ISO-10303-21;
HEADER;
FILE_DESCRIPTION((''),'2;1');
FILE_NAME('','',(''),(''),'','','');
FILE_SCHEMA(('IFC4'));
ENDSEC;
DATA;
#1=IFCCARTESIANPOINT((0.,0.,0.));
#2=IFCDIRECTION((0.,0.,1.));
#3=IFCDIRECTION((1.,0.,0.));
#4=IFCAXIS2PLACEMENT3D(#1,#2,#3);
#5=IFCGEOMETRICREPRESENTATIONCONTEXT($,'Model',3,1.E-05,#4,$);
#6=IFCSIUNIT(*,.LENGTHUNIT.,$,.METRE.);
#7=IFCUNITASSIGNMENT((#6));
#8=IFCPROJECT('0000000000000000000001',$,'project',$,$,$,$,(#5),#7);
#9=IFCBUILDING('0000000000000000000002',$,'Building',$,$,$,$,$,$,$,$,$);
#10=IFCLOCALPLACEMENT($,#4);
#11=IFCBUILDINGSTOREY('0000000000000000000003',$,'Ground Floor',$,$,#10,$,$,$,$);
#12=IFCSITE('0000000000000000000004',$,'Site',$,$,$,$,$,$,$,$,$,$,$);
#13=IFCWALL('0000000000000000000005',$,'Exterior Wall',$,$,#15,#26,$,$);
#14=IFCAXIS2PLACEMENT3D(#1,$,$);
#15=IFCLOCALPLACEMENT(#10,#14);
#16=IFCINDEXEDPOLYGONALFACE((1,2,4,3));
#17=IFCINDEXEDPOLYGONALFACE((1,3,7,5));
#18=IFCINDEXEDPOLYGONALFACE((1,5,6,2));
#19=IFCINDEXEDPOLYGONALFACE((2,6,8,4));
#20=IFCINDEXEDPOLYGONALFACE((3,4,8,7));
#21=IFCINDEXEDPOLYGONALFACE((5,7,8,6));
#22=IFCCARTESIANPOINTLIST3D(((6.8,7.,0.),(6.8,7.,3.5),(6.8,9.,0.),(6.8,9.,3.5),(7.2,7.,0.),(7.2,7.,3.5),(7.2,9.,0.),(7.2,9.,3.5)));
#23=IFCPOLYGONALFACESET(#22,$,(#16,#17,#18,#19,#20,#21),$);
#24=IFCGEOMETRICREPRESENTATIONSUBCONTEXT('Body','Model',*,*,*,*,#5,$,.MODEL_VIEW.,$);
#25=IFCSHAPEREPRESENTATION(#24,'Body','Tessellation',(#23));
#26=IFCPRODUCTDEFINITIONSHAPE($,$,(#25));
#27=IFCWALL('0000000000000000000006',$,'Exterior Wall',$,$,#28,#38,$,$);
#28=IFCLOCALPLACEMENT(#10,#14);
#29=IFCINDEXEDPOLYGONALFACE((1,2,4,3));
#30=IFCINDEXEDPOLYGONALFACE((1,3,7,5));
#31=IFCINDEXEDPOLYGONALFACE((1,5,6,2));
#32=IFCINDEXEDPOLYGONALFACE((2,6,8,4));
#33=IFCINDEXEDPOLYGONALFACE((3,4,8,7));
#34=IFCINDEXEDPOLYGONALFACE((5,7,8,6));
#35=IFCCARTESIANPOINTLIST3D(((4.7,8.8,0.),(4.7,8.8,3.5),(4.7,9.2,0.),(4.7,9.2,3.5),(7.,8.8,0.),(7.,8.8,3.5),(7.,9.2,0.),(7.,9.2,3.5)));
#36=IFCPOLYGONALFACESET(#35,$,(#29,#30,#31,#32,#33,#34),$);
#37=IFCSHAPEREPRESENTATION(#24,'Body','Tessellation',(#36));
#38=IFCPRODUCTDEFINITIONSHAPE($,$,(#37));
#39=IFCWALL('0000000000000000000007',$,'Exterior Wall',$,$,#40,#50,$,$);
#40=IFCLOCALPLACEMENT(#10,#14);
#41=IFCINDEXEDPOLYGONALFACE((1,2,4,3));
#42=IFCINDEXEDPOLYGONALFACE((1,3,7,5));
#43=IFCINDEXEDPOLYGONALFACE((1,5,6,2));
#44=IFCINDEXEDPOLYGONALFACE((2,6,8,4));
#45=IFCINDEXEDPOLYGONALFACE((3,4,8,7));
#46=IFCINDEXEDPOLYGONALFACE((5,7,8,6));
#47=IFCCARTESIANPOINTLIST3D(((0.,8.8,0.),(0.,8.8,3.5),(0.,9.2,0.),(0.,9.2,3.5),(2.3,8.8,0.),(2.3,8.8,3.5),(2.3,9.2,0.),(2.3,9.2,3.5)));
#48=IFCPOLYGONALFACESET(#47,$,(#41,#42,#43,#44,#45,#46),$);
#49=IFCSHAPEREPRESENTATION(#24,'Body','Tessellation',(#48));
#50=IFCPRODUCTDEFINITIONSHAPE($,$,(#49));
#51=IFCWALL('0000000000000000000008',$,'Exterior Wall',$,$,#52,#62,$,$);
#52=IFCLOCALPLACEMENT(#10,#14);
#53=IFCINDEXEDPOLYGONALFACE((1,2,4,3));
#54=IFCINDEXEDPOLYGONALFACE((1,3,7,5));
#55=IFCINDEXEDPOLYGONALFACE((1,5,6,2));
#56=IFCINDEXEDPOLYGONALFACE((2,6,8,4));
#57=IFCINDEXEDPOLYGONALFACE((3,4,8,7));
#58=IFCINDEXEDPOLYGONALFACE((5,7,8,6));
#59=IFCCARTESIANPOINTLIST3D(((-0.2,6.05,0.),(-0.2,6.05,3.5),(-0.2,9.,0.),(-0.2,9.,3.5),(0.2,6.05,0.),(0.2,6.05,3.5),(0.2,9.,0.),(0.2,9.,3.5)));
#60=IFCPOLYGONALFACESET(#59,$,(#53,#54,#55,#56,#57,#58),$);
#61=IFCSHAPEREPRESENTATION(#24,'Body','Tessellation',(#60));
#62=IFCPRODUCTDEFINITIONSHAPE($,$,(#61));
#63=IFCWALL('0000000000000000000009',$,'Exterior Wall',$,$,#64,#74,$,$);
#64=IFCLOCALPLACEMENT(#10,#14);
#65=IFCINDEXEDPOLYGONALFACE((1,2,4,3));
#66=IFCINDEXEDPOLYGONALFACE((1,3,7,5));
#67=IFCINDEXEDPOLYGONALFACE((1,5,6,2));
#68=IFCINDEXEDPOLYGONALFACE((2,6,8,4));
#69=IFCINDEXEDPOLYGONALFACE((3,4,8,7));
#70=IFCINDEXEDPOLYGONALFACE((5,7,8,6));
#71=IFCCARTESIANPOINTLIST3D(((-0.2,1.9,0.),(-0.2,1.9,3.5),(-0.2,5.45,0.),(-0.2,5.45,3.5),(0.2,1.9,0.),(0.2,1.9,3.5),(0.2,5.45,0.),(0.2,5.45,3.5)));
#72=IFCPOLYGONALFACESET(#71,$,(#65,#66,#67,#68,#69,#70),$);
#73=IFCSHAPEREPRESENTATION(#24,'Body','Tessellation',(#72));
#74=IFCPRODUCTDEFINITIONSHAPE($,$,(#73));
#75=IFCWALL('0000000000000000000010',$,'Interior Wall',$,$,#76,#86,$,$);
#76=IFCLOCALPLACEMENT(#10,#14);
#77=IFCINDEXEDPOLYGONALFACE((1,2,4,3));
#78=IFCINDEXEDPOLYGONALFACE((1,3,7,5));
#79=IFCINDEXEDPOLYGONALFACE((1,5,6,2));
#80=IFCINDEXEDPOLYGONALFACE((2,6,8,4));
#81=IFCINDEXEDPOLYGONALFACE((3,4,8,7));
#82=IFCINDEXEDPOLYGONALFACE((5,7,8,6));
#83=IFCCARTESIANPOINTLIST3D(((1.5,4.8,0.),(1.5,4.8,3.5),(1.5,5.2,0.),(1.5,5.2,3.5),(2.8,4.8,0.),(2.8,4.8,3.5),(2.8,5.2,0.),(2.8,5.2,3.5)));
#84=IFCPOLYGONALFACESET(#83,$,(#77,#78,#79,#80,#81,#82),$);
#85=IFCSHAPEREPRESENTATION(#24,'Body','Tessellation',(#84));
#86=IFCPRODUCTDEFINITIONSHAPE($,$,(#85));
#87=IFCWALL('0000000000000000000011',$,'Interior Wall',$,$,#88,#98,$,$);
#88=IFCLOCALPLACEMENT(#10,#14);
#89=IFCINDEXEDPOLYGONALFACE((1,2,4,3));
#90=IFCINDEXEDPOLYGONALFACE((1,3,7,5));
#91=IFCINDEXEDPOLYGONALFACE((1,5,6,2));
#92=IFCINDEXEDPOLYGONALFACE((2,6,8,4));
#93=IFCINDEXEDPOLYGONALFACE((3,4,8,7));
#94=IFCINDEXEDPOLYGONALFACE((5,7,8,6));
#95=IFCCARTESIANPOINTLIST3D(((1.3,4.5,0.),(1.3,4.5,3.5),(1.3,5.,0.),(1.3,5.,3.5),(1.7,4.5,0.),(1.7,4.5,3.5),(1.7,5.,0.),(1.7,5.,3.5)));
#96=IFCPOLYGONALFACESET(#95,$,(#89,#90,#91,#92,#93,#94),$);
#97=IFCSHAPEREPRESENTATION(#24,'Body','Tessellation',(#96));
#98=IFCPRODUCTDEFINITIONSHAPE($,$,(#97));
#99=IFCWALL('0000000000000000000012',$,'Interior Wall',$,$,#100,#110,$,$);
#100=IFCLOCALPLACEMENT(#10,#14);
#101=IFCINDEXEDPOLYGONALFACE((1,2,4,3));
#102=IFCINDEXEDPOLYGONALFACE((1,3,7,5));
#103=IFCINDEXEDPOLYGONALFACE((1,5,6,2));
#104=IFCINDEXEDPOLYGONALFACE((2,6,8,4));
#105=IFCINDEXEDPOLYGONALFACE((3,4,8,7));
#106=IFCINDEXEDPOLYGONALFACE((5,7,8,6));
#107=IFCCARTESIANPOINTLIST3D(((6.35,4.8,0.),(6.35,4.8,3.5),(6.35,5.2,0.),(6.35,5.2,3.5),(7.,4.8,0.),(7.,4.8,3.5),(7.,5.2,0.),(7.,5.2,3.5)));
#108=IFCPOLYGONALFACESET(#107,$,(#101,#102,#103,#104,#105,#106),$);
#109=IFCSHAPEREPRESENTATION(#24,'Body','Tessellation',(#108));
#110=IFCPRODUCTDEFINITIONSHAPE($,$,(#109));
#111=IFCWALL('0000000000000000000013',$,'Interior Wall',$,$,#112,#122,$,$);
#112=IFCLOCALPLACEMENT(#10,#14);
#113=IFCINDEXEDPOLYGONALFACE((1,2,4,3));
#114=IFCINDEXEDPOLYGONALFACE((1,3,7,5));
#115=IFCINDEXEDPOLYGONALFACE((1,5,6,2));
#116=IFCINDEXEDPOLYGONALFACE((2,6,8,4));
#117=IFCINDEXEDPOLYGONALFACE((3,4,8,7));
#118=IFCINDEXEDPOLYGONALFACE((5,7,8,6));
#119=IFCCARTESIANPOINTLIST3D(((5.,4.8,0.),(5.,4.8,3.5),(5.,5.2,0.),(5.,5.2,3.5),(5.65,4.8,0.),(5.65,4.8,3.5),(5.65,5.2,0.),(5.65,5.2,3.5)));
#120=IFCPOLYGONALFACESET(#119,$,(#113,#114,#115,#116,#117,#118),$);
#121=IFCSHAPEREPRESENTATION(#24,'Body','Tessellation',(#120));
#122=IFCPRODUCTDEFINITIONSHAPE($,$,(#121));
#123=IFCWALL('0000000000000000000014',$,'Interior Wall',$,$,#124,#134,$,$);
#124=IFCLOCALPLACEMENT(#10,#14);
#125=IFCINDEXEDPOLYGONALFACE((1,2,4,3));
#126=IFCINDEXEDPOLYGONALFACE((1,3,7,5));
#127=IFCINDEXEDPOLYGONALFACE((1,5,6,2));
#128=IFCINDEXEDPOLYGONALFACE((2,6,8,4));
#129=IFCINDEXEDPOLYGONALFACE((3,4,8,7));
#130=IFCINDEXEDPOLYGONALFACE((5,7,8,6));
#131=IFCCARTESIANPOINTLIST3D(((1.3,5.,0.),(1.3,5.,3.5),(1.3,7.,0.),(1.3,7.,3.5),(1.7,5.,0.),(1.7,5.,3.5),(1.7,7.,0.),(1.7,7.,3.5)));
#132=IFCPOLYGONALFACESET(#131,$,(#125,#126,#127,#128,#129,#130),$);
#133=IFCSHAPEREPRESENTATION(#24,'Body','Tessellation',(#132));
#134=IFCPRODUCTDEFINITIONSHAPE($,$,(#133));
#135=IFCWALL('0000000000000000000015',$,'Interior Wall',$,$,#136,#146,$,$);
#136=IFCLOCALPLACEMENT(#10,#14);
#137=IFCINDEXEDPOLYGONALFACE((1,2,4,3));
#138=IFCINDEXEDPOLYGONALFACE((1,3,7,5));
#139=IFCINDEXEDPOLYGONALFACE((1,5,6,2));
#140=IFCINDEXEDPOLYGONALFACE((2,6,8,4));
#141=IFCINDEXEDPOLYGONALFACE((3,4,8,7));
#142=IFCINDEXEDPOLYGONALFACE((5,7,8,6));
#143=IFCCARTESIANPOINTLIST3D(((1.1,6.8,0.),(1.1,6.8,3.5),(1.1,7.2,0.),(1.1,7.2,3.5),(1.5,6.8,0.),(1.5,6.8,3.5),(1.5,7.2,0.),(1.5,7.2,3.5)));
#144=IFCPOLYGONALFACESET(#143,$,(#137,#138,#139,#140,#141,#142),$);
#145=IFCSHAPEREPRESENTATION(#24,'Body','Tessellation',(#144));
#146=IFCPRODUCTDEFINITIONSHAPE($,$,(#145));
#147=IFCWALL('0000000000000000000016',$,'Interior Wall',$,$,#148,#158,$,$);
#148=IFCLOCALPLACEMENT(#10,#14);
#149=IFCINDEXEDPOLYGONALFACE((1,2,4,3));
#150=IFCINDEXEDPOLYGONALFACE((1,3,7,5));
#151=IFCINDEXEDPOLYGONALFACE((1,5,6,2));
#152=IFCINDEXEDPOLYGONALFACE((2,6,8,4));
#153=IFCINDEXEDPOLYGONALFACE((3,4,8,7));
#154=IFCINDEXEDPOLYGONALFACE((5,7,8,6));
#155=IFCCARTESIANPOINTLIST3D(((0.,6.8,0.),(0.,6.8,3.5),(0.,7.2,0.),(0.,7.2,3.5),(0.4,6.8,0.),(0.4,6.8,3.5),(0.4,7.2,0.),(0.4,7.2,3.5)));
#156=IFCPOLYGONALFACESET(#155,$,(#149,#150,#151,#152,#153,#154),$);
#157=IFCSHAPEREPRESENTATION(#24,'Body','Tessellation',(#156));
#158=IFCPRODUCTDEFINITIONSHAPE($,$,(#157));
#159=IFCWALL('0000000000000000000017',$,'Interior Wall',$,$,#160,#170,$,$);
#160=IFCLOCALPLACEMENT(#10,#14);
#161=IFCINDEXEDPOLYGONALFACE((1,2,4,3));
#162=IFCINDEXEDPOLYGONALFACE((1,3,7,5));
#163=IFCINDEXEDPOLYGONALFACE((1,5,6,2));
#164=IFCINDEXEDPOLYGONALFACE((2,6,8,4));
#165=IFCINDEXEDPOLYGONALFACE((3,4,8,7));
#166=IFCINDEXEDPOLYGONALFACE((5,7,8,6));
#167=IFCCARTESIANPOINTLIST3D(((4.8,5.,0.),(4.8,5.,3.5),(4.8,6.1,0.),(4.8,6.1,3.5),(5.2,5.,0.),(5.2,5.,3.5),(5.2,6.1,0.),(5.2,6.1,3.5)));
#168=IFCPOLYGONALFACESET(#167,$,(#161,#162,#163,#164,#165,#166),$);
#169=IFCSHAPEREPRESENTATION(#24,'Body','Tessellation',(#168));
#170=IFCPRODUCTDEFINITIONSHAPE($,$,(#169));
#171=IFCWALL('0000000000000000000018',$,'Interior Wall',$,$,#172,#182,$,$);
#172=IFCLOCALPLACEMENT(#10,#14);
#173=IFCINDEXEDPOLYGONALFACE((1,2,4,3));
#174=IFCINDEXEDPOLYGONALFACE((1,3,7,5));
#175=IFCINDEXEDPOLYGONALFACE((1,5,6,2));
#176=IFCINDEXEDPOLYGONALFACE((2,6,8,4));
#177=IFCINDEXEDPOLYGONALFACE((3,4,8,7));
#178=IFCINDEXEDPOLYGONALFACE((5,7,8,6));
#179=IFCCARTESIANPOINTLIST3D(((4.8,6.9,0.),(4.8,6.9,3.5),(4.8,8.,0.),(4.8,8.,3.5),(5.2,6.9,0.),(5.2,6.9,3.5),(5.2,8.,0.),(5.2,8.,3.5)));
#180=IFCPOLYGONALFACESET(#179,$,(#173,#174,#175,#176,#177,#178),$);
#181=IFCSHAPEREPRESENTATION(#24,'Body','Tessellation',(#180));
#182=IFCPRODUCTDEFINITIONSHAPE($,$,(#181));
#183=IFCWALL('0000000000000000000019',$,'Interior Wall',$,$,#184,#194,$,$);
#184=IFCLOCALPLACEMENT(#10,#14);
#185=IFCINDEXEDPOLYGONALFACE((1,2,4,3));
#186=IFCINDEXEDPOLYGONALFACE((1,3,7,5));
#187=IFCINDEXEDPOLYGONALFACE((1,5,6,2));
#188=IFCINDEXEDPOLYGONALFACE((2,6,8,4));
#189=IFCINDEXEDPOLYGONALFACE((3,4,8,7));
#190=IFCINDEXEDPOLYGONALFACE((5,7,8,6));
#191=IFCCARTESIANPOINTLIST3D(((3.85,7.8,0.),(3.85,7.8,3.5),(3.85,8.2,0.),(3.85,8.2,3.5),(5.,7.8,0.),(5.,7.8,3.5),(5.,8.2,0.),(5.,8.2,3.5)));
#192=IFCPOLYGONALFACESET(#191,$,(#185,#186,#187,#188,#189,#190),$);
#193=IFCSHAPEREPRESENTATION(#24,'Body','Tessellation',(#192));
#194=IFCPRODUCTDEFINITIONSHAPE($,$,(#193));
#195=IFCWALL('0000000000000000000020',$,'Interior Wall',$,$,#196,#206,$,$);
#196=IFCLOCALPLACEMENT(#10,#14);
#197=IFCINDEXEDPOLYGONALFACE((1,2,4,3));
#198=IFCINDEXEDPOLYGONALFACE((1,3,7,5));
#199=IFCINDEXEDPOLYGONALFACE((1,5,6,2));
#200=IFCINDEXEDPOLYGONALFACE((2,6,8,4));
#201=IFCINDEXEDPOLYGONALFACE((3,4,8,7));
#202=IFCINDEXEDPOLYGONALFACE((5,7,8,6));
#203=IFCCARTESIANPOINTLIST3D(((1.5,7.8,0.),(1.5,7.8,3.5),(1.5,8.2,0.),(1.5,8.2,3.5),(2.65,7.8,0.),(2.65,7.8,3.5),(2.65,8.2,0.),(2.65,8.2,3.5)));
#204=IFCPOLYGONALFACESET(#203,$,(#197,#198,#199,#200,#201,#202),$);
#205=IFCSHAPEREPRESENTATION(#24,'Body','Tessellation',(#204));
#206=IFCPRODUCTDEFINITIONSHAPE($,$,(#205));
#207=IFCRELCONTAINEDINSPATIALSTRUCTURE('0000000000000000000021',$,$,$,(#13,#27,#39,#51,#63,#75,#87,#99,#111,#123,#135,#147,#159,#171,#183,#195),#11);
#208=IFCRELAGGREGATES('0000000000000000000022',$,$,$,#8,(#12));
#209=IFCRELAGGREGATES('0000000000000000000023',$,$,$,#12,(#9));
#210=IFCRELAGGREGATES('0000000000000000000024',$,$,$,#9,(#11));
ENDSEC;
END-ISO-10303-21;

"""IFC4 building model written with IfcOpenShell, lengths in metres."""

from ifc_helpers import new_model, si_unit, frame, origin_with_axes, place, context, subcontext, project, spatial, indexed_curve, outline, extrude, element, save


model = new_model("IFC4")

# Units and contexts
model_context = context("Model", 3, precision=1e-05, world=origin_with_axes())
body_context = subcontext(model_context, "Body", "Model", "MODEL_VIEW")
ifc_project = project(units=[si_unit("LENGTHUNIT", "METRE")], contexts=[model_context])

# Site, building, storey
site = spatial("IfcSite", under=ifc_project, Name="Site")
building = spatial("IfcBuilding", under=site, Name="Building")
storey_placement = place(None, origin_with_axes())
storey = spatial("IfcBuildingStorey", under=building, at=storey_placement, Name="Ground Floor")

# Walls
wall_1_placement = place(storey_placement, frame((7.0, 7.0, 0.0), z_axis=(0.0, 0.0, 1.0), x_axis=(0.0, 1.0, 0.0)))
element("IfcWall", 1, at=wall_1_placement, inside=storey, Name="Exterior Wall", context=body_context, shape_type="SweptSolid", body=[
    extrude(outline(indexed_curve([(0.0, 0.0), (0.0, 0.4), (2.0, 0.4), (2.0, 0.0), (0.0, 0.0)], self_intersect=False)), frame((0.0, -0.2, 0.0), z_axis=(0.0, 0.0, 1.0), x_axis=(1.0, 0.0, 0.0)), (0.0, 0.0, 1.0), 3.5),
])
for number, where, z_axis, x_axis, name in (
    (2, (7.0, 9.0, 0.0), (0.0, 0.0, 1.0), (-1.0, 0.0, 0.0), "Exterior Wall"),
    (3, (2.3, 9.0, 0.0), (0.0, 0.0, 1.0), (-1.0, 0.0, 0.0), "Exterior Wall"),
):
    element("IfcWall", number, at=place(storey_placement, frame(where, z_axis=z_axis, x_axis=x_axis)), inside=storey, Name=name, context=body_context, shape_type="SweptSolid", body=[
        extrude(outline(indexed_curve([(0.0, 0.0), (0.0, 0.4), (2.3, 0.4), (2.3, 0.0), (0.0, 0.0)], self_intersect=False)), frame((0.0, -0.2, 0.0), z_axis=(0.0, 0.0, 1.0), x_axis=(1.0, 0.0, 0.0)), (0.0, 0.0, 1.0), 3.5),
    ])
wall_2_placement = place(storey_placement, frame((0.0, 9.0, 0.0), z_axis=(0.0, 0.0, 1.0), x_axis=(0.0, -1.0, 0.0)))
element("IfcWall", 4, at=wall_2_placement, inside=storey, Name="Exterior Wall", context=body_context, shape_type="SweptSolid", body=[
    extrude(outline(indexed_curve([(0.0, 0.0), (0.0, 0.4), (2.95, 0.4), (2.95, 0.0), (0.0, 0.0)], self_intersect=False)), frame((0.0, -0.2, 0.0), z_axis=(0.0, 0.0, 1.0), x_axis=(1.0, 0.0, 0.0)), (0.0, 0.0, 1.0), 3.5),
])
wall_3_placement = place(storey_placement, frame((0.0, 5.45, 0.0), z_axis=(0.0, 0.0, 1.0), x_axis=(0.0, -1.0, 0.0)))
element("IfcWall", 5, at=wall_3_placement, inside=storey, Name="Exterior Wall", context=body_context, shape_type="SweptSolid", body=[
    extrude(outline(indexed_curve([(0.0, 0.0), (0.0, 0.4), (3.55, 0.4), (3.55, 0.0), (0.0, 0.0)], self_intersect=False)), frame((0.0, -0.2, 0.0), z_axis=(0.0, 0.0, 1.0), x_axis=(1.0, 0.0, 0.0)), (0.0, 0.0, 1.0), 3.5),
])
wall_4_placement = place(storey_placement, frame((2.8, 5.0, 0.0), z_axis=(0.0, 0.0, 1.0), x_axis=(-1.0, 0.0, 0.0)))
element("IfcWall", 6, at=wall_4_placement, inside=storey, Name="Interior Wall", context=body_context, shape_type="SweptSolid", body=[
    extrude(outline(indexed_curve([(0.0, 0.0), (0.0, 0.4), (1.3, 0.4), (1.3, 0.0), (0.0, 0.0)], self_intersect=False)), frame((0.0, -0.2, 0.0), z_axis=(0.0, 0.0, 1.0), x_axis=(1.0, 0.0, 0.0)), (0.0, 0.0, 1.0), 3.5),
])
wall_5_placement = place(storey_placement, frame((1.5, 5.0, 0.0), z_axis=(0.0, 0.0, 1.0), x_axis=(0.0, -1.0, 0.0)))
element("IfcWall", 7, at=wall_5_placement, inside=storey, Name="Interior Wall", context=body_context, shape_type="SweptSolid", body=[
    extrude(outline(indexed_curve([(0.0, 0.0), (0.0, 0.4), (0.5, 0.4), (0.5, 0.0), (0.0, 0.0)], self_intersect=False)), frame((0.0, -0.2, 0.0), z_axis=(0.0, 0.0, 1.0), x_axis=(1.0, 0.0, 0.0)), (0.0, 0.0, 1.0), 3.5),
])
for number, where, z_axis, x_axis, name in (
    (8, (7.0, 5.0, 0.0), (0.0, 0.0, 1.0), (-1.0, 0.0, 0.0), "Interior Wall"),
    (9, (5.65, 5.0, 0.0), (0.0, 0.0, 1.0), (-1.0, 0.0, 0.0), "Interior Wall"),
):
    element("IfcWall", number, at=place(storey_placement, frame(where, z_axis=z_axis, x_axis=x_axis)), inside=storey, Name=name, context=body_context, shape_type="SweptSolid", body=[
        extrude(outline(indexed_curve([(0.0, 0.0), (0.0, 0.4), (0.65, 0.4), (0.65, 0.0), (0.0, 0.0)], self_intersect=False)), frame((0.0, -0.2, 0.0), z_axis=(0.0, 0.0, 1.0), x_axis=(1.0, 0.0, 0.0)), (0.0, 0.0, 1.0), 3.5),
    ])
wall_6_placement = place(storey_placement, frame((1.5, 5.0, 0.0), z_axis=(0.0, 0.0, 1.0), x_axis=(0.0, 1.0, 0.0)))
element("IfcWall", 10, at=wall_6_placement, inside=storey, Name="Interior Wall", context=body_context, shape_type="SweptSolid", body=[
    extrude(outline(indexed_curve([(0.0, 0.0), (0.0, 0.4), (2.0, 0.4), (2.0, 0.0), (0.0, 0.0)], self_intersect=False)), frame((0.0, -0.2, 0.0), z_axis=(0.0, 0.0, 1.0), x_axis=(1.0, 0.0, 0.0)), (0.0, 0.0, 1.0), 3.5),
])
for number, where, z_axis, x_axis, name in (
    (11, (1.5, 7.0, 0.0), (0.0, 0.0, 1.0), (-1.0, 0.0, 0.0), "Interior Wall"),
    (12, (0.4, 7.0, 0.0), (0.0, 0.0, 1.0), (-1.0, 0.0, 0.0), "Interior Wall"),
):
    element("IfcWall", number, at=place(storey_placement, frame(where, z_axis=z_axis, x_axis=x_axis)), inside=storey, Name=name, context=body_context, shape_type="SweptSolid", body=[
        extrude(outline(indexed_curve([(0.0, 0.0), (0.0, 0.4), (0.4, 0.4), (0.4, 0.0), (0.0, 0.0)], self_intersect=False)), frame((0.0, -0.2, 0.0), z_axis=(0.0, 0.0, 1.0), x_axis=(1.0, 0.0, 0.0)), (0.0, 0.0, 1.0), 3.5),
    ])
for number, where, z_axis, x_axis, name in (
    (13, (5.0, 5.0, 0.0), (0.0, 0.0, 1.0), (0.0, 1.0, 0.0), "Interior Wall"),
    (14, (5.0, 6.9, 0.0), (0.0, 0.0, 1.0), (0.0, 1.0, 0.0), "Interior Wall"),
):
    element("IfcWall", number, at=place(storey_placement, frame(where, z_axis=z_axis, x_axis=x_axis)), inside=storey, Name=name, context=body_context, shape_type="SweptSolid", body=[
        extrude(outline(indexed_curve([(0.0, 0.0), (0.0, 0.4), (1.1, 0.4), (1.1, 0.0), (0.0, 0.0)], self_intersect=False)), frame((0.0, -0.2, 0.0), z_axis=(0.0, 0.0, 1.0), x_axis=(1.0, 0.0, 0.0)), (0.0, 0.0, 1.0), 3.5),
    ])
for number, where, z_axis, x_axis, name in (
    (15, (5.0, 8.0, 0.0), (0.0, 0.0, 1.0), (-1.0, 0.0, 0.0), "Interior Wall"),
    (16, (2.65, 8.0, 0.0), (0.0, 0.0, 1.0), (-1.0, 0.0, 0.0), "Interior Wall"),
):
    element("IfcWall", number, at=place(storey_placement, frame(where, z_axis=z_axis, x_axis=x_axis)), inside=storey, Name=name, context=body_context, shape_type="SweptSolid", body=[
        extrude(outline(indexed_curve([(0.0, 0.0), (0.0, 0.4), (1.15, 0.4), (1.15, 0.0), (0.0, 0.0)], self_intersect=False)), frame((0.0, -0.2, 0.0), z_axis=(0.0, 0.0, 1.0), x_axis=(1.0, 0.0, 0.0)), (0.0, 0.0, 1.0), 3.5),
    ])

save(model, "model.ifc")
